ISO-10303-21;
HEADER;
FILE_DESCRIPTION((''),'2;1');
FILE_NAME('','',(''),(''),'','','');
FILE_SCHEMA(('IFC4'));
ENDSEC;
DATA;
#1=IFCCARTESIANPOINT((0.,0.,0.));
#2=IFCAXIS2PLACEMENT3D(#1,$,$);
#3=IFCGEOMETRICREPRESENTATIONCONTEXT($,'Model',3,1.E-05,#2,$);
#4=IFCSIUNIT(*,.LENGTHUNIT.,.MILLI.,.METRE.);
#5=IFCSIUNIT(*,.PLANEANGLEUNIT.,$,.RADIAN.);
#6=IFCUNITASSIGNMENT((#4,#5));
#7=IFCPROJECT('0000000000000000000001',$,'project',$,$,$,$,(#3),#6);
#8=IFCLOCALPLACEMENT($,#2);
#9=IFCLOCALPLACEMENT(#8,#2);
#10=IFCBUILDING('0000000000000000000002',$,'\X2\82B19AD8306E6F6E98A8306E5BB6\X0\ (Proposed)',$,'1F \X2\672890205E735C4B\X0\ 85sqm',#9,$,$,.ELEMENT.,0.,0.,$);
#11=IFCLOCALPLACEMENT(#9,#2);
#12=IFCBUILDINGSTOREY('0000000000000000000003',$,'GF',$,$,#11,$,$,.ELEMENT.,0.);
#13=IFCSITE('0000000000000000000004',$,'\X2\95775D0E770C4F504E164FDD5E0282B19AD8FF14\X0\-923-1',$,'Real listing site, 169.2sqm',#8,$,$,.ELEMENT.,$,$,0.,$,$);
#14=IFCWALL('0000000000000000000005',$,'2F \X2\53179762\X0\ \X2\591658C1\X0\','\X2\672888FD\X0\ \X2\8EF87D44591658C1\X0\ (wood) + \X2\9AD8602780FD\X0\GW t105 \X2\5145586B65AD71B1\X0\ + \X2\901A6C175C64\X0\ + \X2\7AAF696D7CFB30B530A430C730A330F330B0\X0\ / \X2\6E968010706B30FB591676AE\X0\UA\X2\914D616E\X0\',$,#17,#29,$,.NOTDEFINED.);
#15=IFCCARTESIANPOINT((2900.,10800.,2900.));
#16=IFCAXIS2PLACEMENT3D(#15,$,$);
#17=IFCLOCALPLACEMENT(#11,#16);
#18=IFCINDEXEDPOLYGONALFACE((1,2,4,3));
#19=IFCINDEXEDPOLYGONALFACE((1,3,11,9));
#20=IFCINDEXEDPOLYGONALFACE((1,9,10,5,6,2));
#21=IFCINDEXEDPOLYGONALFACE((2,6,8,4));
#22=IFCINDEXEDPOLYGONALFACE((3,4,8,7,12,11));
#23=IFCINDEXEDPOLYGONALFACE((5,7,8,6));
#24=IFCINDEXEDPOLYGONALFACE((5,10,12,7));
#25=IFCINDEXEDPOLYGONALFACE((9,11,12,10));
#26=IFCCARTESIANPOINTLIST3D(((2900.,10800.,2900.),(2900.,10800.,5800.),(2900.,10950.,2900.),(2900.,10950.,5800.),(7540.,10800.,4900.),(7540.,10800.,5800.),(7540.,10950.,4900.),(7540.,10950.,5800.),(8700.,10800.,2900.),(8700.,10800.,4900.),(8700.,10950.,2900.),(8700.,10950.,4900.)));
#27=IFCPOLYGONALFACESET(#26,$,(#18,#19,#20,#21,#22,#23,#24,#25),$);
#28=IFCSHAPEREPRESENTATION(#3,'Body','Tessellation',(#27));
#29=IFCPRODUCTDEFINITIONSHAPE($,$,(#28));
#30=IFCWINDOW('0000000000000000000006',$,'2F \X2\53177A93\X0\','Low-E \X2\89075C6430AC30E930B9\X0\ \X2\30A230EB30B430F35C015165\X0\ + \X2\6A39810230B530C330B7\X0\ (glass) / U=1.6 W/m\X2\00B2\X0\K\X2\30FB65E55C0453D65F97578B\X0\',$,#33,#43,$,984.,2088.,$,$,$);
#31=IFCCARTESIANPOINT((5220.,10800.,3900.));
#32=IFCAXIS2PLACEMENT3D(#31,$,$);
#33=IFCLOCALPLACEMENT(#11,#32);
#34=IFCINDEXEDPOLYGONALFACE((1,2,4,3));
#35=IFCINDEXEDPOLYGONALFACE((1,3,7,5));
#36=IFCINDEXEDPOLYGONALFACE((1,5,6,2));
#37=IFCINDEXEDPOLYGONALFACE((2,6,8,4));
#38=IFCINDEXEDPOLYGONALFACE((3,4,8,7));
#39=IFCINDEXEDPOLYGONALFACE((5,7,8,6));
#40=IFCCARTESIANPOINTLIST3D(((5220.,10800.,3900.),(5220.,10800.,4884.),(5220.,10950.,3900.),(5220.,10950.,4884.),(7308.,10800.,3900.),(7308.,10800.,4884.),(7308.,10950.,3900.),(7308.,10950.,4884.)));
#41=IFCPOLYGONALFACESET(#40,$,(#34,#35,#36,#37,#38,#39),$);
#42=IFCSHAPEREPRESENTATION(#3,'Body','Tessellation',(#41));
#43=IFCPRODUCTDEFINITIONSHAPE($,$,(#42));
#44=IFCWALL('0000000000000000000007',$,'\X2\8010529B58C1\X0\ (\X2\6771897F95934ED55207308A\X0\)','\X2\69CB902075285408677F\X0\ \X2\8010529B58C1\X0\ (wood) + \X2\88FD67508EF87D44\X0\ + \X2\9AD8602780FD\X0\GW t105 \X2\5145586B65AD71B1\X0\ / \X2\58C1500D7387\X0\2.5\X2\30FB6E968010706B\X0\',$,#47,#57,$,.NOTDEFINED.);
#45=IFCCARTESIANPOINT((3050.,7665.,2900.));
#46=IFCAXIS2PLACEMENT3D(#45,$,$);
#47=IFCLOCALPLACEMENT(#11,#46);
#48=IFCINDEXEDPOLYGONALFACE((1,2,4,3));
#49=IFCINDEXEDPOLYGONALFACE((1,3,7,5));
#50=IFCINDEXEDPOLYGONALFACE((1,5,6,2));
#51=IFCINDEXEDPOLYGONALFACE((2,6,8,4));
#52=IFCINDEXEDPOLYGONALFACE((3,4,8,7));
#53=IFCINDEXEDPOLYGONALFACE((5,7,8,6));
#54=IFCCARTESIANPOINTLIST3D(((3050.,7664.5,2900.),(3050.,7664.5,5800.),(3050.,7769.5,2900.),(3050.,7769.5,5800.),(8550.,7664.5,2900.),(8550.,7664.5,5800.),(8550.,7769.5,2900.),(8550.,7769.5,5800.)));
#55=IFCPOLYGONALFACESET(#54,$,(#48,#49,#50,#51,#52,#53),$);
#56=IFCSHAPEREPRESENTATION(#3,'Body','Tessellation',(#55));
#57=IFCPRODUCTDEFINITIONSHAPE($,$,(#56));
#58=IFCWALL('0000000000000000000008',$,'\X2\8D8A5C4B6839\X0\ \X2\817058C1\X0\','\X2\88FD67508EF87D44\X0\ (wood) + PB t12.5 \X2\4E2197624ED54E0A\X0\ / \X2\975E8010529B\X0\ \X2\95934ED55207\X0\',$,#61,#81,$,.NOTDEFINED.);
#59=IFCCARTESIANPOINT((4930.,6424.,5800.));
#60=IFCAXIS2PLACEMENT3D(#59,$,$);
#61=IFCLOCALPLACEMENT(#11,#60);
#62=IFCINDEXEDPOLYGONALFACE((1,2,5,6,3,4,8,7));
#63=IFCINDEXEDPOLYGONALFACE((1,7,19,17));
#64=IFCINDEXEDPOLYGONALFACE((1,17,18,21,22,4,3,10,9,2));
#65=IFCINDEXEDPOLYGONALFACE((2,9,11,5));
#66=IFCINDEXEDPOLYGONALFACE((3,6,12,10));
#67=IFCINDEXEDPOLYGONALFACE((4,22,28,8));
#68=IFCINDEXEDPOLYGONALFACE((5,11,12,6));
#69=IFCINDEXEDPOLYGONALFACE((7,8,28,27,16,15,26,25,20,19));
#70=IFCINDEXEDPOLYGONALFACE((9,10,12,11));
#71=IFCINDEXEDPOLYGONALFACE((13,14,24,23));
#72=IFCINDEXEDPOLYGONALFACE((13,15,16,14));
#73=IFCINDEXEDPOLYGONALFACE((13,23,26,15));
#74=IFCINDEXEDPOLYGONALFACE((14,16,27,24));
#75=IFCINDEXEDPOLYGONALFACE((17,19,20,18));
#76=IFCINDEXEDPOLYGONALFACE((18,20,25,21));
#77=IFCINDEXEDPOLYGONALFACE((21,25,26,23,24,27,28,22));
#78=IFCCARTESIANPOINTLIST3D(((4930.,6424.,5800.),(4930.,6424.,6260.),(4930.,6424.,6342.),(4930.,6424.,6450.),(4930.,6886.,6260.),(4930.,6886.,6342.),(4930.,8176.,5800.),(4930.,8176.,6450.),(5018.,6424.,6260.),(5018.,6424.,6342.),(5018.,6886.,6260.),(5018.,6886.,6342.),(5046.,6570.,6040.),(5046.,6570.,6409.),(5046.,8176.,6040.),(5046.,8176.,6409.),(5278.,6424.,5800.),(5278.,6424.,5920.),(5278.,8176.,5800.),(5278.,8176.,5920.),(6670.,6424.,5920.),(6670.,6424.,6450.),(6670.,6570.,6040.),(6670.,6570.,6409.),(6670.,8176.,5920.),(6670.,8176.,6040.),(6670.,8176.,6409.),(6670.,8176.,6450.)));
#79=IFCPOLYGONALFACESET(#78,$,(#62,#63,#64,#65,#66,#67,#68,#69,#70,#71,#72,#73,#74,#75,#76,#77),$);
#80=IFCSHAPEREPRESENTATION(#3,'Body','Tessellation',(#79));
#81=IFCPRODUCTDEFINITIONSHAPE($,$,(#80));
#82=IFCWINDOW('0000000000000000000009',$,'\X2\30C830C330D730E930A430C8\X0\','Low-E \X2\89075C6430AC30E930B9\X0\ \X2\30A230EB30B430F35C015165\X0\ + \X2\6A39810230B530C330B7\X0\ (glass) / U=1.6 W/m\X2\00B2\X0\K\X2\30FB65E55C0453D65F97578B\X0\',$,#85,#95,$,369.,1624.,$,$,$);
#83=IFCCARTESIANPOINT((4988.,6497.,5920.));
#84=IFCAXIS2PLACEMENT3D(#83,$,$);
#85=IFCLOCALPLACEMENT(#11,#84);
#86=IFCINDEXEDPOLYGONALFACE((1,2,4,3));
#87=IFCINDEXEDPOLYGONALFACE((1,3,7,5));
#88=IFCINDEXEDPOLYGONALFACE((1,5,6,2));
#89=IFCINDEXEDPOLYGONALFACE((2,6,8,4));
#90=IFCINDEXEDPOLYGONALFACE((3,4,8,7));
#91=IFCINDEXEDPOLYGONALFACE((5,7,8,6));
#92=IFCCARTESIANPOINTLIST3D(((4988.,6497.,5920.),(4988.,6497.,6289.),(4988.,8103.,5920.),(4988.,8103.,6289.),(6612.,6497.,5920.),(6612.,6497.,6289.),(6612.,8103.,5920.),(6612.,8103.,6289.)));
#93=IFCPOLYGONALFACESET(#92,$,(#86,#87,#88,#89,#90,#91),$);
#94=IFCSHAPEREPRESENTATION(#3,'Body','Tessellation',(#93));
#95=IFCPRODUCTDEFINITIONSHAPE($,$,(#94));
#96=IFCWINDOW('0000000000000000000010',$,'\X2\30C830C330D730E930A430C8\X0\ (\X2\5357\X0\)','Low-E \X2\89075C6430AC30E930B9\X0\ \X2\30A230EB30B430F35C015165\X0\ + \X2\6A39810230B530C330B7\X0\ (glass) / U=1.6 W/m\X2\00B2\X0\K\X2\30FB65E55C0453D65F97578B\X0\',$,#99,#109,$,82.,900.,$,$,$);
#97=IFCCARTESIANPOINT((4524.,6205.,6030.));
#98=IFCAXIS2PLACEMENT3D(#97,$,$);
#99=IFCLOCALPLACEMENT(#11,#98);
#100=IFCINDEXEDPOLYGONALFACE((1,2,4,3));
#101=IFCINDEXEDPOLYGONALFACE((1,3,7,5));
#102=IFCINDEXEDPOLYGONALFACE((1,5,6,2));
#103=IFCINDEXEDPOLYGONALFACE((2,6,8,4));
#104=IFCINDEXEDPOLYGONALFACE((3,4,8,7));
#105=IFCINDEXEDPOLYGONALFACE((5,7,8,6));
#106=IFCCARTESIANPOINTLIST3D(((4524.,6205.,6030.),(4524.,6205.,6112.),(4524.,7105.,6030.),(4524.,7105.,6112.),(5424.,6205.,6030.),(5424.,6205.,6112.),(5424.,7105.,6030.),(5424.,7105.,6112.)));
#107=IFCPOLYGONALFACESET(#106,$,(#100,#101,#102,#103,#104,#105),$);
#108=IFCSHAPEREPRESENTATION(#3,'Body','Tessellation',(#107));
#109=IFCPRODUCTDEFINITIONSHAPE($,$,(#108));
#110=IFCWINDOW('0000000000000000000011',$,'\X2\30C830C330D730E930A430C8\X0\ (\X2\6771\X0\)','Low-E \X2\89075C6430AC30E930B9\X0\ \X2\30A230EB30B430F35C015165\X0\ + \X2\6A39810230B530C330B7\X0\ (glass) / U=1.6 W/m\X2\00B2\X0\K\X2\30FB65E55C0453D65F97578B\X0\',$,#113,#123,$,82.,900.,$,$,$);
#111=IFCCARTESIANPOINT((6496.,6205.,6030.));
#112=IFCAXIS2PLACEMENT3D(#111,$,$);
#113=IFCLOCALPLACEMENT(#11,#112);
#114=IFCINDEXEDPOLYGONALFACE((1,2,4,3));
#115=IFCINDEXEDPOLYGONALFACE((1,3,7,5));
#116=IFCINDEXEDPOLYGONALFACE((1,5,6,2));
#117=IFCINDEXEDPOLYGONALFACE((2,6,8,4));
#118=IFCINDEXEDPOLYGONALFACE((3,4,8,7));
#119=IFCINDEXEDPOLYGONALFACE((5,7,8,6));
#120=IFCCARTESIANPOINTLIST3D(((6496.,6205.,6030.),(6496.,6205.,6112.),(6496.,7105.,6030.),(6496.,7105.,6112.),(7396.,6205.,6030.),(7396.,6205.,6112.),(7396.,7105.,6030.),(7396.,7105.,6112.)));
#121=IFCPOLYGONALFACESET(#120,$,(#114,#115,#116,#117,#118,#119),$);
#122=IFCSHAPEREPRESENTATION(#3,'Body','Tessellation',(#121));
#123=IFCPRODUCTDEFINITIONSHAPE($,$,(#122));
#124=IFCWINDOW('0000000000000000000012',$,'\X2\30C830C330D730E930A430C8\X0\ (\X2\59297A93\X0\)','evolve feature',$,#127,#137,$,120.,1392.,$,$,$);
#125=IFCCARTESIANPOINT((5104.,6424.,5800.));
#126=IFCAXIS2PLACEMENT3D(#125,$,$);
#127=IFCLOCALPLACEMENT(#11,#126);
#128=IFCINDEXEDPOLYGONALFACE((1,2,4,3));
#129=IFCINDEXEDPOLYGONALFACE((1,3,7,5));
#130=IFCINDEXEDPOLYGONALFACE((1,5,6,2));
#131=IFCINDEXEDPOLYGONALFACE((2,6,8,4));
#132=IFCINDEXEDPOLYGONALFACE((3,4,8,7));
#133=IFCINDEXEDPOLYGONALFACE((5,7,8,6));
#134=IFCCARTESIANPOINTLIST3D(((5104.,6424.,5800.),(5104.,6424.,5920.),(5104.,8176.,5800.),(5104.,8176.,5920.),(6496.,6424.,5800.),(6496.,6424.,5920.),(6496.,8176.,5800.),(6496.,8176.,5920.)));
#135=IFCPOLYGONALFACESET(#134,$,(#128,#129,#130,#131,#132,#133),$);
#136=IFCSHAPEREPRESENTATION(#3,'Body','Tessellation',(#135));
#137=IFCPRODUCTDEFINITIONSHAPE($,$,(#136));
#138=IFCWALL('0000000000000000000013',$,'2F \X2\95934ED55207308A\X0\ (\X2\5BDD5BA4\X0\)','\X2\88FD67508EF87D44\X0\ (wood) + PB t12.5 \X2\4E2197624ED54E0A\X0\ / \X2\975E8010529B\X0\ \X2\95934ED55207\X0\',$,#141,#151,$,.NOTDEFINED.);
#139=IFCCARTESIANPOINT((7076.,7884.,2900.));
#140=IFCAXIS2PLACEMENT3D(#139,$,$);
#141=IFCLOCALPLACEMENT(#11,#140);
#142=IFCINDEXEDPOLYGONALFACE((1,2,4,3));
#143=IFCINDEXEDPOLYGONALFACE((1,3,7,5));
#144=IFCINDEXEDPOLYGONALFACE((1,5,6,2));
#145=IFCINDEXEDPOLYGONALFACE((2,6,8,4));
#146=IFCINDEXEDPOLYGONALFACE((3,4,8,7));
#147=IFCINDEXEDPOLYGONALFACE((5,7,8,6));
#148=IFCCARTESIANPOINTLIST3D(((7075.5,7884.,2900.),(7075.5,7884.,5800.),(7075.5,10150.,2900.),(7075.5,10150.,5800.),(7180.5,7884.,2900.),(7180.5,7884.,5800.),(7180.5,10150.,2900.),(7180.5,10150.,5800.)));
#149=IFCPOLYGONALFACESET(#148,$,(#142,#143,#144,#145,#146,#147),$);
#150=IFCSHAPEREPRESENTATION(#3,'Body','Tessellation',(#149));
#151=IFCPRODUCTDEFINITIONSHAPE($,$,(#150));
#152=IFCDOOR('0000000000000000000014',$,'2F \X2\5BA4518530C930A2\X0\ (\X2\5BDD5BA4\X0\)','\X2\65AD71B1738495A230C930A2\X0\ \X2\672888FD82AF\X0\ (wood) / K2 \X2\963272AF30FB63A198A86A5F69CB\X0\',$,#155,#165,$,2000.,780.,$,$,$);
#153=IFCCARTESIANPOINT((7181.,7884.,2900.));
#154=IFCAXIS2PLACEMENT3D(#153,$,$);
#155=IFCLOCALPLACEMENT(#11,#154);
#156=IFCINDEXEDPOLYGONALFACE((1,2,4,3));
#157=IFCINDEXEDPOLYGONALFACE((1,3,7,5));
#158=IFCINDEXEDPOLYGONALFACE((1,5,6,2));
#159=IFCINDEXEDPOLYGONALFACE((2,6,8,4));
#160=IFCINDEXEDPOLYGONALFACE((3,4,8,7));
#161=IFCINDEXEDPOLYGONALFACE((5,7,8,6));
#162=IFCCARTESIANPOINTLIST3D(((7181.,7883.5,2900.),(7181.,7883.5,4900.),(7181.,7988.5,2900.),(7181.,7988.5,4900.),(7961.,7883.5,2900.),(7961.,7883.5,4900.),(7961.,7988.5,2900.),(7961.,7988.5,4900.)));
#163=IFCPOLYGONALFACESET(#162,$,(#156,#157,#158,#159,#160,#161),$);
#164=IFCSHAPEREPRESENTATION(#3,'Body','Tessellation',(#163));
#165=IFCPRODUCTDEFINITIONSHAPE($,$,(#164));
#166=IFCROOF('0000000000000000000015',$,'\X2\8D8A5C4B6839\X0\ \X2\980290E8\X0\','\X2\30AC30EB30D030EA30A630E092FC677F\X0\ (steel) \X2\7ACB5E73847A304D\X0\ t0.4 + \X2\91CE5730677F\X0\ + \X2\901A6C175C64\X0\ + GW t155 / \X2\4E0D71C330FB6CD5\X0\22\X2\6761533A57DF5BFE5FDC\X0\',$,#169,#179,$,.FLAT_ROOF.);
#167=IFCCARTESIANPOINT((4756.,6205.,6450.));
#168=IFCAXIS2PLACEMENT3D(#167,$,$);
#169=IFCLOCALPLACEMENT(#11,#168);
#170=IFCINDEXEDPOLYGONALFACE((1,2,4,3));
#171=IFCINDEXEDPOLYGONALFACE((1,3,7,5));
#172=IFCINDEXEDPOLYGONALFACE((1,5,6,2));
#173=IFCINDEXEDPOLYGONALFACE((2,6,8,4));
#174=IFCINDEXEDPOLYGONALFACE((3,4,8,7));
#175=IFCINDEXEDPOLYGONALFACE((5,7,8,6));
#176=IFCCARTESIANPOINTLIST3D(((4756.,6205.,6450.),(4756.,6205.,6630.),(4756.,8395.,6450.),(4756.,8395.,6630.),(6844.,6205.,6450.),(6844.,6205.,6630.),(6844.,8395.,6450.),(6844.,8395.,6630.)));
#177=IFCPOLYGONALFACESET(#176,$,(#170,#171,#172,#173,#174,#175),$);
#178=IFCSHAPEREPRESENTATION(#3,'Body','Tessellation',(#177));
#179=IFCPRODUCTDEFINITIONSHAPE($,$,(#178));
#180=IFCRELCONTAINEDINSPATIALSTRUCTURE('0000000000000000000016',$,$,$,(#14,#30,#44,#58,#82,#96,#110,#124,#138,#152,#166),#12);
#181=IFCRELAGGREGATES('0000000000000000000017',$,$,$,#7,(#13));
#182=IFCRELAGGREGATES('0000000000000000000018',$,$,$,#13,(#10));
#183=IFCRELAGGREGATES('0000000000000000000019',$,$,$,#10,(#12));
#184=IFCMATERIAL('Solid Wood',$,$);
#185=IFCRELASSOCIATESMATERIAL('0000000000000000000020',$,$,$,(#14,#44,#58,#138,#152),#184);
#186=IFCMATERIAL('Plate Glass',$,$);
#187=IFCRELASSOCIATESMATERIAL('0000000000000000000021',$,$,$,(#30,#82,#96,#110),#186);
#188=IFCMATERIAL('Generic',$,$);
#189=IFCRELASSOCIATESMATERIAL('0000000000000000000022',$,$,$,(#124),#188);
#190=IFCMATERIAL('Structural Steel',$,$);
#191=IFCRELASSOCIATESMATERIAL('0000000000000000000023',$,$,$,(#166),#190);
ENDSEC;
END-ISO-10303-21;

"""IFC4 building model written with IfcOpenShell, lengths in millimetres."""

from ifc_helpers import new_model, si_unit, frame, frame_2d, origin, place, context, project, spatial, rectangle, extrude, material, element, fill, save


model = new_model("IFC4")

# Units and contexts
model_context = context("Model", 3, precision=1e-05, world=origin())
ifc_project = project(units=[si_unit("LENGTHUNIT", "METRE", prefix="MILLI"), si_unit("PLANEANGLEUNIT", "RADIAN")], contexts=[model_context])

# Site, building, storey
site_placement = place(None, origin())
site = spatial("IfcSite", under=ifc_project, at=site_placement, Name="長崎県佐世保市花高４-923-1", ObjectType="Real listing site, 169.2sqm", CompositionType="ELEMENT", RefElevation=0.0)
building_placement = place(site_placement, origin())
building = spatial("IfcBuilding", under=site, at=building_placement, Name="花高の潮風の家 (Proposed)", ObjectType="1F 木造平屋 85sqm", CompositionType="ELEMENT", ElevationOfRefHeight=0.0, ElevationOfTerrain=0.0)
storey_placement = place(building_placement, origin())
storey = spatial("IfcBuildingStorey", under=building, at=storey_placement, Name="GF", CompositionType="ELEMENT", Elevation=0.0)

# Wall, opening, window
ifc_material_1 = material(Name="Solid Wood")
wall_1_placement = place(storey_placement, frame((2900.0, 10800.0, 2900.0)))
wall_1 = element("IfcWall", 1, at=wall_1_placement, inside=storey, material=ifc_material_1, Name="2F 北面 外壁", Description="木製 軸組外壁 (wood) + 高性能GW t105 充填断熱 + 通気層 + 窯業系サイディング / 準耐火・外皮UA配慮", PredefinedType="NOTDEFINED", context=model_context, shape_type="SweptSolid", body=[
    extrude(rectangle(XDim=5800.0, YDim=150.0, at=frame_2d((2900.0, 75.0))), frame((2900.0, 10800.0, 2900.0)), (0.0, 0.0, 1.0), 2900.0),
])
opening_1_placement = place(storey_placement, frame((5220.0, 10800.0, 3900.0)))
opening_1 = element("IfcOpeningElement", 2, at=opening_1_placement, cuts=wall_1, PredefinedType="NOTDEFINED", context=model_context, shape_type="SweptSolid", body=[
    extrude(rectangle(XDim=2088.0, YDim=150.0, at=frame_2d((1044.0, 75.0))), frame((5220.0, 10800.0, 3900.0)), (0.0, 0.0, 1.0), 984.0),
])
ifc_material_2 = material(Name="Plate Glass")
window_1_placement = place(storey_placement, frame((5220.0, 10800.0, 3900.0)))
window_1 = element("IfcWindow", 3, at=window_1_placement, inside=storey, material=ifc_material_2, Name="2F 北窓", Description="Low-E 複層ガラス アルゴン封入 + 樹脂サッシ (glass) / U=1.6 W/m²K・日射取得型", OverallHeight=984.0, OverallWidth=2088.0, context=model_context, shape_type="SweptSolid", body=[
    extrude(rectangle(XDim=2088.0, YDim=150.0, at=frame_2d((1044.0, 75.0))), frame((5220.0, 10800.0, 3900.0)), (0.0, 0.0, 1.0), 984.0),
])
fill(opening_1, window_1)

# Wall
wall_2_placement = place(storey_placement, frame((3050.0, 7665.0, 2900.0)))
element("IfcWall", 4, at=wall_2_placement, inside=storey, material=ifc_material_1, Name="耐力壁 (東西間仕切り)", Description="構造用合板 耐力壁 (wood) + 製材軸組 + 高性能GW t105 充填断熱 / 壁倍率2.5・準耐火", PredefinedType="NOTDEFINED", context=model_context, shape_type="SweptSolid", body=[
    extrude(rectangle(XDim=5500.0, YDim=105.0, at=frame_2d((2750.0, 52.0))), frame((3050.0, 7665.0, 2900.0)), (0.0, 0.0, 1.0), 2900.0),
])

# Wall, openings, windows
wall_3_placement = place(storey_placement, frame((4930.0, 6424.0, 5800.0)))
wall_3 = element("IfcWall", 5, at=wall_3_placement, inside=storey, material=ifc_material_1, Name="越屋根 腰壁", Description="製材軸組 (wood) + PB t12.5 両面仕上 / 非耐力 間仕切", PredefinedType="NOTDEFINED", context=model_context, shape_type="SweptSolid", body=[
    extrude(rectangle(XDim=1740.0, YDim=1752.0, at=frame_2d((870.0, 876.0))), frame((4930.0, 6424.0, 5800.0)), (0.0, 0.0, 1.0), 650.0),
])
opening_2_placement = place(storey_placement, frame((4988.0, 6497.0, 5920.0)))
opening_2 = element("IfcOpeningElement", 6, at=opening_2_placement, cuts=wall_3, PredefinedType="NOTDEFINED", context=model_context, shape_type="SweptSolid", body=[
    extrude(rectangle(XDim=1624.0, YDim=1606.0, at=frame_2d((812.0, 803.0))), frame((4988.0, 6497.0, 5920.0)), (0.0, 0.0, 1.0), 369.0),
])
opening_3_placement = place(storey_placement, frame((4524.0, 6205.0, 6030.0)))
opening_3 = element("IfcOpeningElement", 7, at=opening_3_placement, cuts=wall_3, PredefinedType="NOTDEFINED", context=model_context, shape_type="SweptSolid", body=[
    extrude(rectangle(XDim=900.0, YDim=900.0, at=frame_2d((450.0, 450.0))), frame((4524.0, 6205.0, 6030.0)), (0.0, 0.0, 1.0), 82.0),
])
opening_4_placement = place(storey_placement, frame((6496.0, 6205.0, 6030.0)))
opening_4 = element("IfcOpeningElement", 8, at=opening_4_placement, cuts=wall_3, PredefinedType="NOTDEFINED", context=model_context, shape_type="SweptSolid", body=[
    extrude(rectangle(XDim=900.0, YDim=900.0, at=frame_2d((450.0, 450.0))), frame((6496.0, 6205.0, 6030.0)), (0.0, 0.0, 1.0), 82.0),
])
opening_5_placement = place(storey_placement, frame((5104.0, 6424.0, 5800.0)))
opening_5 = element("IfcOpeningElement", 9, at=opening_5_placement, cuts=wall_3, PredefinedType="NOTDEFINED", context=model_context, shape_type="SweptSolid", body=[
    extrude(rectangle(XDim=1392.0, YDim=1752.0, at=frame_2d((696.0, 876.0))), frame((5104.0, 6424.0, 5800.0)), (0.0, 0.0, 1.0), 120.0),
])
window_2_placement = place(storey_placement, frame((4988.0, 6497.0, 5920.0)))
window_2 = element("IfcWindow", 10, at=window_2_placement, inside=storey, material=ifc_material_2, Name="トップライト", Description="Low-E 複層ガラス アルゴン封入 + 樹脂サッシ (glass) / U=1.6 W/m²K・日射取得型", OverallHeight=369.0, OverallWidth=1624.0, context=model_context, shape_type="SweptSolid", body=[
    extrude(rectangle(XDim=1624.0, YDim=1606.0, at=frame_2d((812.0, 803.0))), frame((4988.0, 6497.0, 5920.0)), (0.0, 0.0, 1.0), 369.0),
])
fill(opening_2, window_2)
window_3_placement = place(storey_placement, frame((4524.0, 6205.0, 6030.0)))
window_3 = element("IfcWindow", 11, at=window_3_placement, inside=storey, material=ifc_material_2, Name="トップライト (南)", Description="Low-E 複層ガラス アルゴン封入 + 樹脂サッシ (glass) / U=1.6 W/m²K・日射取得型", OverallHeight=82.0, OverallWidth=900.0, context=model_context, shape_type="SweptSolid", body=[
    extrude(rectangle(XDim=900.0, YDim=900.0, at=frame_2d((450.0, 450.0))), frame((4524.0, 6205.0, 6030.0)), (0.0, 0.0, 1.0), 82.0),
])
fill(opening_3, window_3)
window_4_placement = place(storey_placement, frame((6496.0, 6205.0, 6030.0)))
window_4 = element("IfcWindow", 12, at=window_4_placement, inside=storey, material=ifc_material_2, Name="トップライト (東)", Description="Low-E 複層ガラス アルゴン封入 + 樹脂サッシ (glass) / U=1.6 W/m²K・日射取得型", OverallHeight=82.0, OverallWidth=900.0, context=model_context, shape_type="SweptSolid", body=[
    extrude(rectangle(XDim=900.0, YDim=900.0, at=frame_2d((450.0, 450.0))), frame((6496.0, 6205.0, 6030.0)), (0.0, 0.0, 1.0), 82.0),
])
fill(opening_4, window_4)
ifc_material_3 = material(Name="Generic")
window_5_placement = place(storey_placement, frame((5104.0, 6424.0, 5800.0)))
window_5 = element("IfcWindow", 13, at=window_5_placement, inside=storey, material=ifc_material_3, Name="トップライト (天窓)", Description="evolve feature", OverallHeight=120.0, OverallWidth=1392.0, context=model_context, shape_type="SweptSolid", body=[
    extrude(rectangle(XDim=1392.0, YDim=1752.0, at=frame_2d((696.0, 876.0))), frame((5104.0, 6424.0, 5800.0)), (0.0, 0.0, 1.0), 120.0),
])
fill(opening_5, window_5)

# Wall
wall_4_placement = place(storey_placement, frame((7076.0, 7884.0, 2900.0)))
element("IfcWall", 14, at=wall_4_placement, inside=storey, material=ifc_material_1, Name="2F 間仕切り (寝室)", Description="製材軸組 (wood) + PB t12.5 両面仕上 / 非耐力 間仕切", PredefinedType="NOTDEFINED", context=model_context, shape_type="SweptSolid", body=[
    extrude(rectangle(XDim=105.0, YDim=2266.0, at=frame_2d((52.0, 1133.0))), frame((7076.0, 7884.0, 2900.0)), (0.0, 0.0, 1.0), 2900.0),
])

# Door
door_placement = place(storey_placement, frame((7181.0, 7884.0, 2900.0)))
element("IfcDoor", 15, at=door_placement, inside=storey, material=ifc_material_1, Name="2F 室内ドア (寝室)", Description="断熱玄関ドア 木製芯 (wood) / K2 防犯・採風機構", OverallHeight=2000.0, OverallWidth=780.0, context=model_context, shape_type="SweptSolid", body=[
    extrude(rectangle(XDim=780.0, YDim=105.0, at=frame_2d((390.0, 52.0))), frame((7181.0, 7884.0, 2900.0)), (0.0, 0.0, 1.0), 2000.0),
])

# Roof
ifc_material_4 = material(Name="Structural Steel")
roof_placement = place(storey_placement, frame((4756.0, 6205.0, 6450.0)))
element("IfcRoof", 16, at=roof_placement, inside=storey, material=ifc_material_4, Name="越屋根 頂部", Description="ガルバリウム鋼板 (steel) 立平葺き t0.4 + 野地板 + 通気層 + GW t155 / 不燃・法22条区域対応", PredefinedType="FLAT_ROOF", context=model_context, shape_type="SweptSolid", body=[
    extrude(rectangle(XDim=2088.0, YDim=2190.0, at=frame_2d((1044.0, 1095.0))), frame((4756.0, 6205.0, 6450.0)), (0.0, 0.0, 1.0), 180.0),
])

save(model, "model.ifc")
